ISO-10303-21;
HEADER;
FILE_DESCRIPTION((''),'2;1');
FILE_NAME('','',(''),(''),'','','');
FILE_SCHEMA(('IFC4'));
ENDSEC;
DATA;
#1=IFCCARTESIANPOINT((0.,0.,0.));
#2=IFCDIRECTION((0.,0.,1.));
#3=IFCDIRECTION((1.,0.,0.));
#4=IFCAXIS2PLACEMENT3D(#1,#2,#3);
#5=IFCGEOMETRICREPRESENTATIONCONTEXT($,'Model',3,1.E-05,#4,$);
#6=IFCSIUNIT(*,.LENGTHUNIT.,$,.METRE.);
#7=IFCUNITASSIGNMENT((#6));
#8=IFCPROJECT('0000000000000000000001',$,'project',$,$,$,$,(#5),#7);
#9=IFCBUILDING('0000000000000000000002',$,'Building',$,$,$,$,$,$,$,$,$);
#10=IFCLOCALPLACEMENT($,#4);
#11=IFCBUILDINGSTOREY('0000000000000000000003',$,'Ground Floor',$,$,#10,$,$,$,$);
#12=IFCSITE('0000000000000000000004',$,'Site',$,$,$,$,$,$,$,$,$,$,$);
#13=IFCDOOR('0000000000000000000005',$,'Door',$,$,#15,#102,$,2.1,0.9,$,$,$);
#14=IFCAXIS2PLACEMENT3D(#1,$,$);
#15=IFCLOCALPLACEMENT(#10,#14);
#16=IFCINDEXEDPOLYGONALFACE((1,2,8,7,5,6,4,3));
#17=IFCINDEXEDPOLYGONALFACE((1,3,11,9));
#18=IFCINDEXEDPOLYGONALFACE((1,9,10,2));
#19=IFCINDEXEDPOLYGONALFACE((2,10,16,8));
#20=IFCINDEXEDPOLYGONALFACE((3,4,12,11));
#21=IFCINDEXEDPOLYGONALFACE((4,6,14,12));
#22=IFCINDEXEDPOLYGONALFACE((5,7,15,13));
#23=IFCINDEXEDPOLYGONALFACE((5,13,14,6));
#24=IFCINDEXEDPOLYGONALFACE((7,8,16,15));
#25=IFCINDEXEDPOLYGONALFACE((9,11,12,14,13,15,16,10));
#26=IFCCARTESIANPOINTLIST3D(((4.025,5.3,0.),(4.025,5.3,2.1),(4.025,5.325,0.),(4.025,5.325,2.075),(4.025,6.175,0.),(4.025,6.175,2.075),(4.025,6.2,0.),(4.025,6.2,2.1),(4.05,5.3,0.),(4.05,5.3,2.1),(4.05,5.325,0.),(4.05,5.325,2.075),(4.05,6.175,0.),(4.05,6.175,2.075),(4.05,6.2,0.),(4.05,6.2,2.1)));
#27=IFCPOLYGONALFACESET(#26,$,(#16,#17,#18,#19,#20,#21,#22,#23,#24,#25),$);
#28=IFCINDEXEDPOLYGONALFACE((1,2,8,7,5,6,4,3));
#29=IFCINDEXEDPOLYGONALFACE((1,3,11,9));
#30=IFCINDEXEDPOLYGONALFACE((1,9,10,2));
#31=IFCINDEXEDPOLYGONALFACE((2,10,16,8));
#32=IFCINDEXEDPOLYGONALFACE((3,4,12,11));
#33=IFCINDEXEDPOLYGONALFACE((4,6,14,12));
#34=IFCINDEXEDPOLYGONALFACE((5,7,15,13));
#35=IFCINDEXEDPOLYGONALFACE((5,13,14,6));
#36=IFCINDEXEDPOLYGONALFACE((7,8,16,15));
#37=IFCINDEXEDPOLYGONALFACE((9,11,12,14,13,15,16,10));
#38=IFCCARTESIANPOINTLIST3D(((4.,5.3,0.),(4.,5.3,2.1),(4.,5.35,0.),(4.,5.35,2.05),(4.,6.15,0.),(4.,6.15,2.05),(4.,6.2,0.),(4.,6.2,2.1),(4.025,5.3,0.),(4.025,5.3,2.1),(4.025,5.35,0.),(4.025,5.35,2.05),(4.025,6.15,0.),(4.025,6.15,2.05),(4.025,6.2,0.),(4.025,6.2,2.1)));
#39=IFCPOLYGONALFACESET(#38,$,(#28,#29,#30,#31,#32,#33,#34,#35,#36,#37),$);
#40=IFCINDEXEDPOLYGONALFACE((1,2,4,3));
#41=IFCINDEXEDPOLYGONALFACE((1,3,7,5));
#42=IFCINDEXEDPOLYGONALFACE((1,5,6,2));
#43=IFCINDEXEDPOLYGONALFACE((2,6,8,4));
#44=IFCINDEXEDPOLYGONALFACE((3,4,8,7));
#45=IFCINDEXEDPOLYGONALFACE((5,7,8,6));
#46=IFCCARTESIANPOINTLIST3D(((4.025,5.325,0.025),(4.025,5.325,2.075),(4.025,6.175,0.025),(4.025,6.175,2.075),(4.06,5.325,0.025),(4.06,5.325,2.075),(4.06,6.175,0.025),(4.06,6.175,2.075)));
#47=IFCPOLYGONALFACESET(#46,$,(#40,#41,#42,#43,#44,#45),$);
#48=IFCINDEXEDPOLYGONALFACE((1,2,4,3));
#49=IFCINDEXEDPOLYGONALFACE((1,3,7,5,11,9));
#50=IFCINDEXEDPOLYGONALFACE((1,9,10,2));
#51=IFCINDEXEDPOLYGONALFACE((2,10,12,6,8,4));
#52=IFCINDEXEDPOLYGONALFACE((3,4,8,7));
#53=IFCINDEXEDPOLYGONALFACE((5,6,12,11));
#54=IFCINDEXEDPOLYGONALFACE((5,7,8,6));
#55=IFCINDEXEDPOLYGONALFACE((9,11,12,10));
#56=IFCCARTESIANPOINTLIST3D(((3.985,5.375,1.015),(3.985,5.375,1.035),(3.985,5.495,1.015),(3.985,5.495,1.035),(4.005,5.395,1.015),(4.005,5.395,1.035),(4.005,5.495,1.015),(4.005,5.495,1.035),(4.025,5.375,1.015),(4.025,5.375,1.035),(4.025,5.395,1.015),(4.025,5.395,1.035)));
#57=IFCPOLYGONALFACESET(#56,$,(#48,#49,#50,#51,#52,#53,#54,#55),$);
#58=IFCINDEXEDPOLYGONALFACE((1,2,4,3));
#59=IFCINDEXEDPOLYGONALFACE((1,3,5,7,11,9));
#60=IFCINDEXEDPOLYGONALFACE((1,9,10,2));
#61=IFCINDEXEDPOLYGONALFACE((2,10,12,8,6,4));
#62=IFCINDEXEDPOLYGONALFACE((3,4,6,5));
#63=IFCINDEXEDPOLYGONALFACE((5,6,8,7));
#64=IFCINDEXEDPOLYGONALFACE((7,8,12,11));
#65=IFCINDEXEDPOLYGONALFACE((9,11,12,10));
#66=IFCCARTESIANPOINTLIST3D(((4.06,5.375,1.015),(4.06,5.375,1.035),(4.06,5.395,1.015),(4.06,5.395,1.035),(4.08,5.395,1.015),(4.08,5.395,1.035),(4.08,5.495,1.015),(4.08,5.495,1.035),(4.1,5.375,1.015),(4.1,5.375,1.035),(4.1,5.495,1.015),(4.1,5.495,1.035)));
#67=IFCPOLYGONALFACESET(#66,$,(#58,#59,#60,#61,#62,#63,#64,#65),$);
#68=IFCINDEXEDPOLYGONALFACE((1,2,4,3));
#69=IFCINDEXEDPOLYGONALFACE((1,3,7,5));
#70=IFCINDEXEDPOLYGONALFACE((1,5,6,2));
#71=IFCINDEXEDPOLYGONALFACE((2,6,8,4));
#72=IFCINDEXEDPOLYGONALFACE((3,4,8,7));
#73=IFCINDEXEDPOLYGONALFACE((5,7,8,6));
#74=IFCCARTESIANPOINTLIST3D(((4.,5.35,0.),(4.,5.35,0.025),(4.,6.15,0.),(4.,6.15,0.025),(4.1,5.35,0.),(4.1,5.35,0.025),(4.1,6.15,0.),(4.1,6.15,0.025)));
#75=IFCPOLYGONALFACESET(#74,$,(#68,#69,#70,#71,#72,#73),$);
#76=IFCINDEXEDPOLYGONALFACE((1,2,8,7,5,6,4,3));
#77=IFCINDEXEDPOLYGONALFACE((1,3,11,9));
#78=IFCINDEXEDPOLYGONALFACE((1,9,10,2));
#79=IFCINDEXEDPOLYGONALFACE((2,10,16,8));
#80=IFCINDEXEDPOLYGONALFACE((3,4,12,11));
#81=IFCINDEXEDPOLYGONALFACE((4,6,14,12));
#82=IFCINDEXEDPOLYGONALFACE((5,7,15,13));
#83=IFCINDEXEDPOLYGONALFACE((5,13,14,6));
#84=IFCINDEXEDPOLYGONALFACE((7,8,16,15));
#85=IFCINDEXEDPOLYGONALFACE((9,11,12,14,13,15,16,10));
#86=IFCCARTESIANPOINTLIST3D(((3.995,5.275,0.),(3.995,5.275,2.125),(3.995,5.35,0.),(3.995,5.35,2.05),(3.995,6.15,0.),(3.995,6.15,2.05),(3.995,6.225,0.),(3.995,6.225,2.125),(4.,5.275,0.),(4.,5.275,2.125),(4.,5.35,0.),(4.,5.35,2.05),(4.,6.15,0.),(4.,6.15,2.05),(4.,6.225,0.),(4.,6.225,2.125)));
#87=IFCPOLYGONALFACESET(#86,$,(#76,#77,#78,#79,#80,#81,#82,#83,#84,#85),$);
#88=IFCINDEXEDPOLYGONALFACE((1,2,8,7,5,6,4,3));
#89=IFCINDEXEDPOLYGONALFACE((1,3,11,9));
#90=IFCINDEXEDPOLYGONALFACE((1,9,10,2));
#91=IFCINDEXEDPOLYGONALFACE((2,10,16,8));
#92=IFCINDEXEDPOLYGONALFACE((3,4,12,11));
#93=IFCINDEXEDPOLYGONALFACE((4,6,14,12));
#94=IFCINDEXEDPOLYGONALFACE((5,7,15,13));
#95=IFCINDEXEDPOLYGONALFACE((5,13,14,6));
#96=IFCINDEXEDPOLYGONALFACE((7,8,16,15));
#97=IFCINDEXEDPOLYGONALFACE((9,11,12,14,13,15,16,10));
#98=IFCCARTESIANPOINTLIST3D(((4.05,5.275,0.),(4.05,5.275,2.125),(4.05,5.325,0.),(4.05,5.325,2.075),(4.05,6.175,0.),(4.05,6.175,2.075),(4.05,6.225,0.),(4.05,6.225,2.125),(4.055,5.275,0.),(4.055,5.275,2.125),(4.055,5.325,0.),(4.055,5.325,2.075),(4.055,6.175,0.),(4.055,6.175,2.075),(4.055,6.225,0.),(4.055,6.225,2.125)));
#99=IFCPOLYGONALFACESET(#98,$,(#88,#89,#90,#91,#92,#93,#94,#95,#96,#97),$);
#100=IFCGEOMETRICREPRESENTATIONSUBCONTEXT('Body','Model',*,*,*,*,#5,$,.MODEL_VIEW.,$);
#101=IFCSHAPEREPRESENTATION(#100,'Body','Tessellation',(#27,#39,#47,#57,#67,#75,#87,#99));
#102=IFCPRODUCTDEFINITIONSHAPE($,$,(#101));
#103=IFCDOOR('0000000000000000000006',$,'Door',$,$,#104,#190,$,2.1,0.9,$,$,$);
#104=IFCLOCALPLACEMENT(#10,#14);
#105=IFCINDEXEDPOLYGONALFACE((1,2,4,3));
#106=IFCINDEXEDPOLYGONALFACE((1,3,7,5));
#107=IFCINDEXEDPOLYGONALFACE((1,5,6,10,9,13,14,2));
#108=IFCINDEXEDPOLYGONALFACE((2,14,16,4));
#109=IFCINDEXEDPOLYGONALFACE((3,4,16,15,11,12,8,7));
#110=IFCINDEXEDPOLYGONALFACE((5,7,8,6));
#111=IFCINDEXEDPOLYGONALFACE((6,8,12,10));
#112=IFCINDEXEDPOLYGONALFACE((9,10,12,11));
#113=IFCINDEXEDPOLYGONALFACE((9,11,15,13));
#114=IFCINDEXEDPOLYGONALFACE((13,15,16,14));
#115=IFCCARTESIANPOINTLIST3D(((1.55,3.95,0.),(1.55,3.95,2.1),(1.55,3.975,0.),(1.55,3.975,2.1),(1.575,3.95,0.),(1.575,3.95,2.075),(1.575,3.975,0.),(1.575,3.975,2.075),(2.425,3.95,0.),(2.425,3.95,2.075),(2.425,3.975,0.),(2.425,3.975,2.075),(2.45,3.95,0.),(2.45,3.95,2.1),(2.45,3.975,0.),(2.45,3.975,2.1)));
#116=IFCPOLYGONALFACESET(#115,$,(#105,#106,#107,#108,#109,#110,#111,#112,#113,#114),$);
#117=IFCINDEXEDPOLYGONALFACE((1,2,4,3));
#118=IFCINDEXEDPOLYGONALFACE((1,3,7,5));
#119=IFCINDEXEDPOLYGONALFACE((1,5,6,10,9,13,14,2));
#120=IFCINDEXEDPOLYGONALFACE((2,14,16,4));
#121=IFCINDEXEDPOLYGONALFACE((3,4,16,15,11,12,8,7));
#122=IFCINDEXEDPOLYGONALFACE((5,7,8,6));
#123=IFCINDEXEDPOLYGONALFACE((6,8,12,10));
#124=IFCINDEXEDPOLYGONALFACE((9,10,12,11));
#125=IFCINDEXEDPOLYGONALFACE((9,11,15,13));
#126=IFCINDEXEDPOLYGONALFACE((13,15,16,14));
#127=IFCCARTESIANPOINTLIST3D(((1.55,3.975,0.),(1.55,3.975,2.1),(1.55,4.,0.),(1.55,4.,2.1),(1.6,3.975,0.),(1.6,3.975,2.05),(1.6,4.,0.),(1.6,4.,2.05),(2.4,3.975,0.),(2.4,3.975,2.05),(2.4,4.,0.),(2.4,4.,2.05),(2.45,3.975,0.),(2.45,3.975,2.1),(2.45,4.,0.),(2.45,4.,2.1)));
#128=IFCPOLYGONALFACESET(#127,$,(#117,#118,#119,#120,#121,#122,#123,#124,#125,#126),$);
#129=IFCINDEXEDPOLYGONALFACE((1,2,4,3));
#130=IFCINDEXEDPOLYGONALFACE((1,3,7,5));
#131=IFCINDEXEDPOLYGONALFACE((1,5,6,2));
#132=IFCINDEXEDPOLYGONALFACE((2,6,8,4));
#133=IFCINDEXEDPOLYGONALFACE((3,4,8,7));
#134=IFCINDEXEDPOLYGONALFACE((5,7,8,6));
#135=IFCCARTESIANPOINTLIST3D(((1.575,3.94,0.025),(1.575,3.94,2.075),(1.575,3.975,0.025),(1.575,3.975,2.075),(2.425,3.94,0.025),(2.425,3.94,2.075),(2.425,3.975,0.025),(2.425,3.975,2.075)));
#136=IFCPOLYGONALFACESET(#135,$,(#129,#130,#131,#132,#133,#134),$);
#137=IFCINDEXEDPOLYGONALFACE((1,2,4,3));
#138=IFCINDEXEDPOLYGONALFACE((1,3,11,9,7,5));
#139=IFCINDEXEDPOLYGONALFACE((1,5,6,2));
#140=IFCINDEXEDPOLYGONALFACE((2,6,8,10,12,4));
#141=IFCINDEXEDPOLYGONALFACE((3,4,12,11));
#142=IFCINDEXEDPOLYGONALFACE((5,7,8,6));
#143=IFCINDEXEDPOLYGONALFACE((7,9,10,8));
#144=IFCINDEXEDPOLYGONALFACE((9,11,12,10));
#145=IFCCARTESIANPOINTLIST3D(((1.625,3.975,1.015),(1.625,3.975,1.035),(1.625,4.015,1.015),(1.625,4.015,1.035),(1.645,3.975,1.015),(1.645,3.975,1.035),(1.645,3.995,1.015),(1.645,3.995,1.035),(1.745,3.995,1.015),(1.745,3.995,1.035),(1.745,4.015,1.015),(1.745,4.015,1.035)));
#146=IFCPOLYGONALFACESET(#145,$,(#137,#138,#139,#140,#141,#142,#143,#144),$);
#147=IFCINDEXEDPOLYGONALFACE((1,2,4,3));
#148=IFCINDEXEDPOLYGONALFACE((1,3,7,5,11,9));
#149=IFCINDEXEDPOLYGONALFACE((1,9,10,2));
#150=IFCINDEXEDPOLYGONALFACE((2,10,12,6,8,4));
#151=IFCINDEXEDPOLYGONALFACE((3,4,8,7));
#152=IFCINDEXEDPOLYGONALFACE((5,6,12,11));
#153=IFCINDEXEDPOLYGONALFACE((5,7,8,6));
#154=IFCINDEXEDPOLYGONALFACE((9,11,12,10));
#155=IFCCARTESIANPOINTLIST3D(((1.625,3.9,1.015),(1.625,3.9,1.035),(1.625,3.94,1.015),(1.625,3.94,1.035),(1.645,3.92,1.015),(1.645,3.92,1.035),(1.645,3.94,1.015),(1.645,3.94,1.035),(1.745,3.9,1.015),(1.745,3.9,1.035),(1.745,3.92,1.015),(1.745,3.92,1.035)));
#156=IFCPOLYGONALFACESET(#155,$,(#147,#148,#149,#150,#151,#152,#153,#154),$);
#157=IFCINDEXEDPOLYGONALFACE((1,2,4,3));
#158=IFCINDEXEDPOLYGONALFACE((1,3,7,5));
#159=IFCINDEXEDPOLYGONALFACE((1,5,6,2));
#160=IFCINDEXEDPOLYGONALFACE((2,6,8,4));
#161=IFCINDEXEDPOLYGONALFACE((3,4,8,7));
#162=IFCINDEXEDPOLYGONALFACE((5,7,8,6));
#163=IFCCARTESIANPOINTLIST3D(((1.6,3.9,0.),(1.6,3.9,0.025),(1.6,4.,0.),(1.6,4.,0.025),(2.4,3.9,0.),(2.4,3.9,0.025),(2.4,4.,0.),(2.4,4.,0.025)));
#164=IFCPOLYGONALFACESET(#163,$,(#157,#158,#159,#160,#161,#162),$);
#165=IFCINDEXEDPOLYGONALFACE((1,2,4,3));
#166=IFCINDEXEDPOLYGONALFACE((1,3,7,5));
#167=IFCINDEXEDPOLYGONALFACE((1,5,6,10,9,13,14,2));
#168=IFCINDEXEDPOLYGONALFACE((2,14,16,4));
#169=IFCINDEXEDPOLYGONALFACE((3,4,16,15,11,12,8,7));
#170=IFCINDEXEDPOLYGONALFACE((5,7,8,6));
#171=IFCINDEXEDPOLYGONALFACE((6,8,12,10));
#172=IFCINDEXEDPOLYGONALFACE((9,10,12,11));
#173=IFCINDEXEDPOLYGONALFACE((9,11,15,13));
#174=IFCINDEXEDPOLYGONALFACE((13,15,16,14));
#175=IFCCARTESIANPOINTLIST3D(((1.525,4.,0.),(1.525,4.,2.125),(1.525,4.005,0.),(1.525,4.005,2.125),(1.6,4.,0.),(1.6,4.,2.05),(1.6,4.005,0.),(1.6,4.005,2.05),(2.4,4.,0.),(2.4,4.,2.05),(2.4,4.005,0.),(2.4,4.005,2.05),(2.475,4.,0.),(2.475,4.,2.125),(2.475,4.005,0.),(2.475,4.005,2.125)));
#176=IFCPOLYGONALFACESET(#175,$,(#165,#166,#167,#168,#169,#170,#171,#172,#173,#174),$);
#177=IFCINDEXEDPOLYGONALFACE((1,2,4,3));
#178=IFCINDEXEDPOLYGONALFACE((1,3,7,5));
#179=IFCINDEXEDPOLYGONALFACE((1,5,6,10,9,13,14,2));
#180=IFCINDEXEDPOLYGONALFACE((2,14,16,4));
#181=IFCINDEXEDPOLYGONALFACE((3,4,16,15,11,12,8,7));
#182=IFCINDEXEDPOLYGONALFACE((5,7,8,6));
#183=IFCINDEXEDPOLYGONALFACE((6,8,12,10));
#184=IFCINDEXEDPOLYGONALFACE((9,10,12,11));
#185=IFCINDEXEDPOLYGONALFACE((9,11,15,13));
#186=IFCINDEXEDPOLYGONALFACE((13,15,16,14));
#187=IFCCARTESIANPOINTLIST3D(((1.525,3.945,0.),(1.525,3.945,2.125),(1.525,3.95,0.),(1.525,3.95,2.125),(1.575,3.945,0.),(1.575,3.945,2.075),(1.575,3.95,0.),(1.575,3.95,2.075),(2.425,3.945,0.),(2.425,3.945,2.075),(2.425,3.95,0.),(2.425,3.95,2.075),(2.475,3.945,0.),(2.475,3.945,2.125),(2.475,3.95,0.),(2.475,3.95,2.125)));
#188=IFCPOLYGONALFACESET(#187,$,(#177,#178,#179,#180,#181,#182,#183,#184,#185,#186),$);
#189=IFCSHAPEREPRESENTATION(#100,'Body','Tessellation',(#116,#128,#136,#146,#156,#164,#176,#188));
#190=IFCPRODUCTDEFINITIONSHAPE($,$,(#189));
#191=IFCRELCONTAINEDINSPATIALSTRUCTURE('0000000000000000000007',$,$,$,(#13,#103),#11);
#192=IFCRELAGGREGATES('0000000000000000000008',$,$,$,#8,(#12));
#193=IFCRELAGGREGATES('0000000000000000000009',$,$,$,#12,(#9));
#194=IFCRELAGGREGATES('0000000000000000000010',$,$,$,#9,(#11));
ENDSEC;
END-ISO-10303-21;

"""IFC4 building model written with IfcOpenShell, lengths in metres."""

from ifc_helpers import new_model, si_unit, frame, origin_with_axes, place, context, subcontext, project, spatial, line, indexed_curve, outline, extrude, element, save


model = new_model("IFC4")

# Units and contexts
model_context = context("Model", 3, precision=1e-05, world=origin_with_axes())
body_context = subcontext(model_context, "Body", "Model", "MODEL_VIEW")
ifc_project = project(units=[si_unit("LENGTHUNIT", "METRE")], contexts=[model_context])

# Site, building, storey
site = spatial("IfcSite", under=ifc_project, Name="Site")
building = spatial("IfcBuilding", under=site, Name="Building")
storey_placement = place(None, origin_with_axes())
storey = spatial("IfcBuildingStorey", under=building, at=storey_placement, Name="Ground Floor")

# Doors
door_1_placement = place(storey_placement, frame((4.0, 6.2, 0.0), z_axis=(0.0, 0.0, 1.0), x_axis=(0.0, -1.0, 0.0)))
element("IfcDoor", 1, at=door_1_placement, inside=storey, Name="Door", OverallHeight=2.1, OverallWidth=0.9, context=body_context, shape_type="SweptSolid", body=[
    extrude(outline(indexed_curve([(0.0, 0.0), (0.0, 2.1), (0.9, 2.1), (0.9, 0.0), (0.875, 0.0), (0.875, 2.075), (0.025, 2.075), (0.025, 0.0)], segments=[line(1, 2, 3, 4, 5, 6, 7, 8, 1)])), frame((0.0, 0.025, 0.0), z_axis=(0.0, -1.0, 0.0), x_axis=(1.0, 0.0, 0.0)), (0.0, 0.0, -1.0), 0.025),
    extrude(outline(indexed_curve([(0.0, 0.0), (0.0, 2.1), (0.9, 2.1), (0.9, 0.0), (0.85, 0.0), (0.85, 2.05), (0.05, 2.05), (0.05, 0.0)], segments=[line(1, 2, 3, 4, 5, 6, 7, 8, 1)])), frame((0.0, 0.0, 0.0), z_axis=(0.0, -1.0, 0.0), x_axis=(1.0, 0.0, 0.0)), (0.0, 0.0, -1.0), 0.025),
    extrude(outline(indexed_curve([(0.0, 0.0), (0.85, 0.0), (0.85, 0.035), (0.0, 0.035)], segments=[line(1, 2, 3, 4, 1)])), frame((0.025, 0.025, 0.025), z_axis=(0.0, 0.0, 1.0), x_axis=(1.0, 0.0, 0.0)), (0.0, 0.0, 1.0), 2.05),
    extrude(outline(indexed_curve([(0.0, 0.0), (0.0, -0.04), (-0.12, -0.04), (-0.12, -0.02), (-0.02, -0.02), (-0.02, 0.0)], segments=[line(1, 2, 3, 4, 5, 6, 1)])), frame((0.825, 0.025, 1.015), z_axis=(0.0, 0.0, 1.0), x_axis=(1.0, 0.0, 0.0)), (0.0, 0.0, 1.0), 0.02),
    extrude(outline(indexed_curve([(0.0, 0.0), (0.0, 0.04), (-0.12, 0.04), (-0.12, 0.02), (-0.02, 0.02), (-0.02, 0.0)], segments=[line(1, 2, 3, 4, 5, 6, 1)])), frame((0.825, 0.06, 1.015), z_axis=(0.0, 0.0, 1.0), x_axis=(1.0, 0.0, 0.0)), (0.0, 0.0, 1.0), 0.02),
    extrude(outline(indexed_curve([(0.0, 0.0), (0.8, 0.0), (0.8, 0.1), (0.0, 0.1)], segments=[line(1, 2, 3, 4, 1)])), frame((0.05, 0.0, 0.0), z_axis=(0.0, 0.0, 1.0), x_axis=(1.0, 0.0, 0.0)), (0.0, 0.0, 1.0), 0.025),
    extrude(outline(indexed_curve([(0.0, 0.0), (0.0, 2.125), (0.95, 2.125), (0.95, 0.0), (0.875, 0.0), (0.875, 2.05), (0.075, 2.05), (0.075, 0.0)], segments=[line(1, 2, 3, 4, 5, 6, 7, 8, 1)])), frame((-0.025, -0.005, 0.0), z_axis=(0.0, -1.0, 0.0), x_axis=(1.0, 0.0, 0.0)), (0.0, 0.0, -1.0), 0.005),
    extrude(outline(indexed_curve([(0.0, 0.0), (0.0, 2.125), (0.95, 2.125), (0.95, 0.0), (0.9, 0.0), (0.9, 2.075), (0.05, 2.075), (0.05, 0.0)], segments=[line(1, 2, 3, 4, 5, 6, 7, 8, 1)])), frame((-0.025, 0.05, 0.0), z_axis=(0.0, -1.0, 0.0), x_axis=(1.0, 0.0, 0.0)), (0.0, 0.0, -1.0), 0.005),
])
door_2_placement = place(storey_placement, frame((2.45, 4.0, 0.0), z_axis=(0.0, 0.0, 1.0), x_axis=(-1.0, 0.0, 0.0)))
element("IfcDoor", 2, at=door_2_placement, inside=storey, Name="Door", OverallHeight=2.1, OverallWidth=0.9, context=body_context, shape_type="SweptSolid", body=[
    extrude(outline(indexed_curve([(0.0, 0.0), (0.0, 2.1), (0.9, 2.1), (0.9, 0.0), (0.875, 0.0), (0.875, 2.075), (0.025, 2.075), (0.025, 0.0)], segments=[line(1, 2, 3, 4, 5, 6, 7, 8, 1)])), frame((0.0, 0.025, 0.0), z_axis=(0.0, -1.0, 0.0), x_axis=(1.0, 0.0, 0.0)), (0.0, 0.0, -1.0), 0.025),
    extrude(outline(indexed_curve([(0.0, 0.0), (0.0, 2.1), (0.9, 2.1), (0.9, 0.0), (0.85, 0.0), (0.85, 2.05), (0.05, 2.05), (0.05, 0.0)], segments=[line(1, 2, 3, 4, 5, 6, 7, 8, 1)])), frame((0.0, 0.0, 0.0), z_axis=(0.0, -1.0, 0.0), x_axis=(1.0, 0.0, 0.0)), (0.0, 0.0, -1.0), 0.025),
    extrude(outline(indexed_curve([(0.0, 0.0), (0.85, 0.0), (0.85, 0.035), (0.0, 0.035)], segments=[line(1, 2, 3, 4, 1)])), frame((0.025, 0.025, 0.025), z_axis=(0.0, 0.0, 1.0), x_axis=(1.0, 0.0, 0.0)), (0.0, 0.0, 1.0), 2.05),
    extrude(outline(indexed_curve([(0.0, 0.0), (0.0, -0.04), (-0.12, -0.04), (-0.12, -0.02), (-0.02, -0.02), (-0.02, 0.0)], segments=[line(1, 2, 3, 4, 5, 6, 1)])), frame((0.825, 0.025, 1.015), z_axis=(0.0, 0.0, 1.0), x_axis=(1.0, 0.0, 0.0)), (0.0, 0.0, 1.0), 0.02),
    extrude(outline(indexed_curve([(0.0, 0.0), (0.0, 0.04), (-0.12, 0.04), (-0.12, 0.02), (-0.02, 0.02), (-0.02, 0.0)], segments=[line(1, 2, 3, 4, 5, 6, 1)])), frame((0.825, 0.06, 1.015), z_axis=(0.0, 0.0, 1.0), x_axis=(1.0, 0.0, 0.0)), (0.0, 0.0, 1.0), 0.02),
    extrude(outline(indexed_curve([(0.0, 0.0), (0.8, 0.0), (0.8, 0.1), (0.0, 0.1)], segments=[line(1, 2, 3, 4, 1)])), frame((0.05, 0.0, 0.0), z_axis=(0.0, 0.0, 1.0), x_axis=(1.0, 0.0, 0.0)), (0.0, 0.0, 1.0), 0.025),
    extrude(outline(indexed_curve([(0.0, 0.0), (0.0, 2.125), (0.95, 2.125), (0.95, 0.0), (0.875, 0.0), (0.875, 2.05), (0.075, 2.05), (0.075, 0.0)], segments=[line(1, 2, 3, 4, 5, 6, 7, 8, 1)])), frame((-0.025, -0.005, 0.0), z_axis=(0.0, -1.0, 0.0), x_axis=(1.0, 0.0, 0.0)), (0.0, 0.0, -1.0), 0.005),
    extrude(outline(indexed_curve([(0.0, 0.0), (0.0, 2.125), (0.95, 2.125), (0.95, 0.0), (0.9, 0.0), (0.9, 2.075), (0.05, 2.075), (0.05, 0.0)], segments=[line(1, 2, 3, 4, 5, 6, 7, 8, 1)])), frame((-0.025, 0.05, 0.0), z_axis=(0.0, -1.0, 0.0), x_axis=(1.0, 0.0, 0.0)), (0.0, 0.0, -1.0), 0.005),
])

save(model, "model.ifc")
